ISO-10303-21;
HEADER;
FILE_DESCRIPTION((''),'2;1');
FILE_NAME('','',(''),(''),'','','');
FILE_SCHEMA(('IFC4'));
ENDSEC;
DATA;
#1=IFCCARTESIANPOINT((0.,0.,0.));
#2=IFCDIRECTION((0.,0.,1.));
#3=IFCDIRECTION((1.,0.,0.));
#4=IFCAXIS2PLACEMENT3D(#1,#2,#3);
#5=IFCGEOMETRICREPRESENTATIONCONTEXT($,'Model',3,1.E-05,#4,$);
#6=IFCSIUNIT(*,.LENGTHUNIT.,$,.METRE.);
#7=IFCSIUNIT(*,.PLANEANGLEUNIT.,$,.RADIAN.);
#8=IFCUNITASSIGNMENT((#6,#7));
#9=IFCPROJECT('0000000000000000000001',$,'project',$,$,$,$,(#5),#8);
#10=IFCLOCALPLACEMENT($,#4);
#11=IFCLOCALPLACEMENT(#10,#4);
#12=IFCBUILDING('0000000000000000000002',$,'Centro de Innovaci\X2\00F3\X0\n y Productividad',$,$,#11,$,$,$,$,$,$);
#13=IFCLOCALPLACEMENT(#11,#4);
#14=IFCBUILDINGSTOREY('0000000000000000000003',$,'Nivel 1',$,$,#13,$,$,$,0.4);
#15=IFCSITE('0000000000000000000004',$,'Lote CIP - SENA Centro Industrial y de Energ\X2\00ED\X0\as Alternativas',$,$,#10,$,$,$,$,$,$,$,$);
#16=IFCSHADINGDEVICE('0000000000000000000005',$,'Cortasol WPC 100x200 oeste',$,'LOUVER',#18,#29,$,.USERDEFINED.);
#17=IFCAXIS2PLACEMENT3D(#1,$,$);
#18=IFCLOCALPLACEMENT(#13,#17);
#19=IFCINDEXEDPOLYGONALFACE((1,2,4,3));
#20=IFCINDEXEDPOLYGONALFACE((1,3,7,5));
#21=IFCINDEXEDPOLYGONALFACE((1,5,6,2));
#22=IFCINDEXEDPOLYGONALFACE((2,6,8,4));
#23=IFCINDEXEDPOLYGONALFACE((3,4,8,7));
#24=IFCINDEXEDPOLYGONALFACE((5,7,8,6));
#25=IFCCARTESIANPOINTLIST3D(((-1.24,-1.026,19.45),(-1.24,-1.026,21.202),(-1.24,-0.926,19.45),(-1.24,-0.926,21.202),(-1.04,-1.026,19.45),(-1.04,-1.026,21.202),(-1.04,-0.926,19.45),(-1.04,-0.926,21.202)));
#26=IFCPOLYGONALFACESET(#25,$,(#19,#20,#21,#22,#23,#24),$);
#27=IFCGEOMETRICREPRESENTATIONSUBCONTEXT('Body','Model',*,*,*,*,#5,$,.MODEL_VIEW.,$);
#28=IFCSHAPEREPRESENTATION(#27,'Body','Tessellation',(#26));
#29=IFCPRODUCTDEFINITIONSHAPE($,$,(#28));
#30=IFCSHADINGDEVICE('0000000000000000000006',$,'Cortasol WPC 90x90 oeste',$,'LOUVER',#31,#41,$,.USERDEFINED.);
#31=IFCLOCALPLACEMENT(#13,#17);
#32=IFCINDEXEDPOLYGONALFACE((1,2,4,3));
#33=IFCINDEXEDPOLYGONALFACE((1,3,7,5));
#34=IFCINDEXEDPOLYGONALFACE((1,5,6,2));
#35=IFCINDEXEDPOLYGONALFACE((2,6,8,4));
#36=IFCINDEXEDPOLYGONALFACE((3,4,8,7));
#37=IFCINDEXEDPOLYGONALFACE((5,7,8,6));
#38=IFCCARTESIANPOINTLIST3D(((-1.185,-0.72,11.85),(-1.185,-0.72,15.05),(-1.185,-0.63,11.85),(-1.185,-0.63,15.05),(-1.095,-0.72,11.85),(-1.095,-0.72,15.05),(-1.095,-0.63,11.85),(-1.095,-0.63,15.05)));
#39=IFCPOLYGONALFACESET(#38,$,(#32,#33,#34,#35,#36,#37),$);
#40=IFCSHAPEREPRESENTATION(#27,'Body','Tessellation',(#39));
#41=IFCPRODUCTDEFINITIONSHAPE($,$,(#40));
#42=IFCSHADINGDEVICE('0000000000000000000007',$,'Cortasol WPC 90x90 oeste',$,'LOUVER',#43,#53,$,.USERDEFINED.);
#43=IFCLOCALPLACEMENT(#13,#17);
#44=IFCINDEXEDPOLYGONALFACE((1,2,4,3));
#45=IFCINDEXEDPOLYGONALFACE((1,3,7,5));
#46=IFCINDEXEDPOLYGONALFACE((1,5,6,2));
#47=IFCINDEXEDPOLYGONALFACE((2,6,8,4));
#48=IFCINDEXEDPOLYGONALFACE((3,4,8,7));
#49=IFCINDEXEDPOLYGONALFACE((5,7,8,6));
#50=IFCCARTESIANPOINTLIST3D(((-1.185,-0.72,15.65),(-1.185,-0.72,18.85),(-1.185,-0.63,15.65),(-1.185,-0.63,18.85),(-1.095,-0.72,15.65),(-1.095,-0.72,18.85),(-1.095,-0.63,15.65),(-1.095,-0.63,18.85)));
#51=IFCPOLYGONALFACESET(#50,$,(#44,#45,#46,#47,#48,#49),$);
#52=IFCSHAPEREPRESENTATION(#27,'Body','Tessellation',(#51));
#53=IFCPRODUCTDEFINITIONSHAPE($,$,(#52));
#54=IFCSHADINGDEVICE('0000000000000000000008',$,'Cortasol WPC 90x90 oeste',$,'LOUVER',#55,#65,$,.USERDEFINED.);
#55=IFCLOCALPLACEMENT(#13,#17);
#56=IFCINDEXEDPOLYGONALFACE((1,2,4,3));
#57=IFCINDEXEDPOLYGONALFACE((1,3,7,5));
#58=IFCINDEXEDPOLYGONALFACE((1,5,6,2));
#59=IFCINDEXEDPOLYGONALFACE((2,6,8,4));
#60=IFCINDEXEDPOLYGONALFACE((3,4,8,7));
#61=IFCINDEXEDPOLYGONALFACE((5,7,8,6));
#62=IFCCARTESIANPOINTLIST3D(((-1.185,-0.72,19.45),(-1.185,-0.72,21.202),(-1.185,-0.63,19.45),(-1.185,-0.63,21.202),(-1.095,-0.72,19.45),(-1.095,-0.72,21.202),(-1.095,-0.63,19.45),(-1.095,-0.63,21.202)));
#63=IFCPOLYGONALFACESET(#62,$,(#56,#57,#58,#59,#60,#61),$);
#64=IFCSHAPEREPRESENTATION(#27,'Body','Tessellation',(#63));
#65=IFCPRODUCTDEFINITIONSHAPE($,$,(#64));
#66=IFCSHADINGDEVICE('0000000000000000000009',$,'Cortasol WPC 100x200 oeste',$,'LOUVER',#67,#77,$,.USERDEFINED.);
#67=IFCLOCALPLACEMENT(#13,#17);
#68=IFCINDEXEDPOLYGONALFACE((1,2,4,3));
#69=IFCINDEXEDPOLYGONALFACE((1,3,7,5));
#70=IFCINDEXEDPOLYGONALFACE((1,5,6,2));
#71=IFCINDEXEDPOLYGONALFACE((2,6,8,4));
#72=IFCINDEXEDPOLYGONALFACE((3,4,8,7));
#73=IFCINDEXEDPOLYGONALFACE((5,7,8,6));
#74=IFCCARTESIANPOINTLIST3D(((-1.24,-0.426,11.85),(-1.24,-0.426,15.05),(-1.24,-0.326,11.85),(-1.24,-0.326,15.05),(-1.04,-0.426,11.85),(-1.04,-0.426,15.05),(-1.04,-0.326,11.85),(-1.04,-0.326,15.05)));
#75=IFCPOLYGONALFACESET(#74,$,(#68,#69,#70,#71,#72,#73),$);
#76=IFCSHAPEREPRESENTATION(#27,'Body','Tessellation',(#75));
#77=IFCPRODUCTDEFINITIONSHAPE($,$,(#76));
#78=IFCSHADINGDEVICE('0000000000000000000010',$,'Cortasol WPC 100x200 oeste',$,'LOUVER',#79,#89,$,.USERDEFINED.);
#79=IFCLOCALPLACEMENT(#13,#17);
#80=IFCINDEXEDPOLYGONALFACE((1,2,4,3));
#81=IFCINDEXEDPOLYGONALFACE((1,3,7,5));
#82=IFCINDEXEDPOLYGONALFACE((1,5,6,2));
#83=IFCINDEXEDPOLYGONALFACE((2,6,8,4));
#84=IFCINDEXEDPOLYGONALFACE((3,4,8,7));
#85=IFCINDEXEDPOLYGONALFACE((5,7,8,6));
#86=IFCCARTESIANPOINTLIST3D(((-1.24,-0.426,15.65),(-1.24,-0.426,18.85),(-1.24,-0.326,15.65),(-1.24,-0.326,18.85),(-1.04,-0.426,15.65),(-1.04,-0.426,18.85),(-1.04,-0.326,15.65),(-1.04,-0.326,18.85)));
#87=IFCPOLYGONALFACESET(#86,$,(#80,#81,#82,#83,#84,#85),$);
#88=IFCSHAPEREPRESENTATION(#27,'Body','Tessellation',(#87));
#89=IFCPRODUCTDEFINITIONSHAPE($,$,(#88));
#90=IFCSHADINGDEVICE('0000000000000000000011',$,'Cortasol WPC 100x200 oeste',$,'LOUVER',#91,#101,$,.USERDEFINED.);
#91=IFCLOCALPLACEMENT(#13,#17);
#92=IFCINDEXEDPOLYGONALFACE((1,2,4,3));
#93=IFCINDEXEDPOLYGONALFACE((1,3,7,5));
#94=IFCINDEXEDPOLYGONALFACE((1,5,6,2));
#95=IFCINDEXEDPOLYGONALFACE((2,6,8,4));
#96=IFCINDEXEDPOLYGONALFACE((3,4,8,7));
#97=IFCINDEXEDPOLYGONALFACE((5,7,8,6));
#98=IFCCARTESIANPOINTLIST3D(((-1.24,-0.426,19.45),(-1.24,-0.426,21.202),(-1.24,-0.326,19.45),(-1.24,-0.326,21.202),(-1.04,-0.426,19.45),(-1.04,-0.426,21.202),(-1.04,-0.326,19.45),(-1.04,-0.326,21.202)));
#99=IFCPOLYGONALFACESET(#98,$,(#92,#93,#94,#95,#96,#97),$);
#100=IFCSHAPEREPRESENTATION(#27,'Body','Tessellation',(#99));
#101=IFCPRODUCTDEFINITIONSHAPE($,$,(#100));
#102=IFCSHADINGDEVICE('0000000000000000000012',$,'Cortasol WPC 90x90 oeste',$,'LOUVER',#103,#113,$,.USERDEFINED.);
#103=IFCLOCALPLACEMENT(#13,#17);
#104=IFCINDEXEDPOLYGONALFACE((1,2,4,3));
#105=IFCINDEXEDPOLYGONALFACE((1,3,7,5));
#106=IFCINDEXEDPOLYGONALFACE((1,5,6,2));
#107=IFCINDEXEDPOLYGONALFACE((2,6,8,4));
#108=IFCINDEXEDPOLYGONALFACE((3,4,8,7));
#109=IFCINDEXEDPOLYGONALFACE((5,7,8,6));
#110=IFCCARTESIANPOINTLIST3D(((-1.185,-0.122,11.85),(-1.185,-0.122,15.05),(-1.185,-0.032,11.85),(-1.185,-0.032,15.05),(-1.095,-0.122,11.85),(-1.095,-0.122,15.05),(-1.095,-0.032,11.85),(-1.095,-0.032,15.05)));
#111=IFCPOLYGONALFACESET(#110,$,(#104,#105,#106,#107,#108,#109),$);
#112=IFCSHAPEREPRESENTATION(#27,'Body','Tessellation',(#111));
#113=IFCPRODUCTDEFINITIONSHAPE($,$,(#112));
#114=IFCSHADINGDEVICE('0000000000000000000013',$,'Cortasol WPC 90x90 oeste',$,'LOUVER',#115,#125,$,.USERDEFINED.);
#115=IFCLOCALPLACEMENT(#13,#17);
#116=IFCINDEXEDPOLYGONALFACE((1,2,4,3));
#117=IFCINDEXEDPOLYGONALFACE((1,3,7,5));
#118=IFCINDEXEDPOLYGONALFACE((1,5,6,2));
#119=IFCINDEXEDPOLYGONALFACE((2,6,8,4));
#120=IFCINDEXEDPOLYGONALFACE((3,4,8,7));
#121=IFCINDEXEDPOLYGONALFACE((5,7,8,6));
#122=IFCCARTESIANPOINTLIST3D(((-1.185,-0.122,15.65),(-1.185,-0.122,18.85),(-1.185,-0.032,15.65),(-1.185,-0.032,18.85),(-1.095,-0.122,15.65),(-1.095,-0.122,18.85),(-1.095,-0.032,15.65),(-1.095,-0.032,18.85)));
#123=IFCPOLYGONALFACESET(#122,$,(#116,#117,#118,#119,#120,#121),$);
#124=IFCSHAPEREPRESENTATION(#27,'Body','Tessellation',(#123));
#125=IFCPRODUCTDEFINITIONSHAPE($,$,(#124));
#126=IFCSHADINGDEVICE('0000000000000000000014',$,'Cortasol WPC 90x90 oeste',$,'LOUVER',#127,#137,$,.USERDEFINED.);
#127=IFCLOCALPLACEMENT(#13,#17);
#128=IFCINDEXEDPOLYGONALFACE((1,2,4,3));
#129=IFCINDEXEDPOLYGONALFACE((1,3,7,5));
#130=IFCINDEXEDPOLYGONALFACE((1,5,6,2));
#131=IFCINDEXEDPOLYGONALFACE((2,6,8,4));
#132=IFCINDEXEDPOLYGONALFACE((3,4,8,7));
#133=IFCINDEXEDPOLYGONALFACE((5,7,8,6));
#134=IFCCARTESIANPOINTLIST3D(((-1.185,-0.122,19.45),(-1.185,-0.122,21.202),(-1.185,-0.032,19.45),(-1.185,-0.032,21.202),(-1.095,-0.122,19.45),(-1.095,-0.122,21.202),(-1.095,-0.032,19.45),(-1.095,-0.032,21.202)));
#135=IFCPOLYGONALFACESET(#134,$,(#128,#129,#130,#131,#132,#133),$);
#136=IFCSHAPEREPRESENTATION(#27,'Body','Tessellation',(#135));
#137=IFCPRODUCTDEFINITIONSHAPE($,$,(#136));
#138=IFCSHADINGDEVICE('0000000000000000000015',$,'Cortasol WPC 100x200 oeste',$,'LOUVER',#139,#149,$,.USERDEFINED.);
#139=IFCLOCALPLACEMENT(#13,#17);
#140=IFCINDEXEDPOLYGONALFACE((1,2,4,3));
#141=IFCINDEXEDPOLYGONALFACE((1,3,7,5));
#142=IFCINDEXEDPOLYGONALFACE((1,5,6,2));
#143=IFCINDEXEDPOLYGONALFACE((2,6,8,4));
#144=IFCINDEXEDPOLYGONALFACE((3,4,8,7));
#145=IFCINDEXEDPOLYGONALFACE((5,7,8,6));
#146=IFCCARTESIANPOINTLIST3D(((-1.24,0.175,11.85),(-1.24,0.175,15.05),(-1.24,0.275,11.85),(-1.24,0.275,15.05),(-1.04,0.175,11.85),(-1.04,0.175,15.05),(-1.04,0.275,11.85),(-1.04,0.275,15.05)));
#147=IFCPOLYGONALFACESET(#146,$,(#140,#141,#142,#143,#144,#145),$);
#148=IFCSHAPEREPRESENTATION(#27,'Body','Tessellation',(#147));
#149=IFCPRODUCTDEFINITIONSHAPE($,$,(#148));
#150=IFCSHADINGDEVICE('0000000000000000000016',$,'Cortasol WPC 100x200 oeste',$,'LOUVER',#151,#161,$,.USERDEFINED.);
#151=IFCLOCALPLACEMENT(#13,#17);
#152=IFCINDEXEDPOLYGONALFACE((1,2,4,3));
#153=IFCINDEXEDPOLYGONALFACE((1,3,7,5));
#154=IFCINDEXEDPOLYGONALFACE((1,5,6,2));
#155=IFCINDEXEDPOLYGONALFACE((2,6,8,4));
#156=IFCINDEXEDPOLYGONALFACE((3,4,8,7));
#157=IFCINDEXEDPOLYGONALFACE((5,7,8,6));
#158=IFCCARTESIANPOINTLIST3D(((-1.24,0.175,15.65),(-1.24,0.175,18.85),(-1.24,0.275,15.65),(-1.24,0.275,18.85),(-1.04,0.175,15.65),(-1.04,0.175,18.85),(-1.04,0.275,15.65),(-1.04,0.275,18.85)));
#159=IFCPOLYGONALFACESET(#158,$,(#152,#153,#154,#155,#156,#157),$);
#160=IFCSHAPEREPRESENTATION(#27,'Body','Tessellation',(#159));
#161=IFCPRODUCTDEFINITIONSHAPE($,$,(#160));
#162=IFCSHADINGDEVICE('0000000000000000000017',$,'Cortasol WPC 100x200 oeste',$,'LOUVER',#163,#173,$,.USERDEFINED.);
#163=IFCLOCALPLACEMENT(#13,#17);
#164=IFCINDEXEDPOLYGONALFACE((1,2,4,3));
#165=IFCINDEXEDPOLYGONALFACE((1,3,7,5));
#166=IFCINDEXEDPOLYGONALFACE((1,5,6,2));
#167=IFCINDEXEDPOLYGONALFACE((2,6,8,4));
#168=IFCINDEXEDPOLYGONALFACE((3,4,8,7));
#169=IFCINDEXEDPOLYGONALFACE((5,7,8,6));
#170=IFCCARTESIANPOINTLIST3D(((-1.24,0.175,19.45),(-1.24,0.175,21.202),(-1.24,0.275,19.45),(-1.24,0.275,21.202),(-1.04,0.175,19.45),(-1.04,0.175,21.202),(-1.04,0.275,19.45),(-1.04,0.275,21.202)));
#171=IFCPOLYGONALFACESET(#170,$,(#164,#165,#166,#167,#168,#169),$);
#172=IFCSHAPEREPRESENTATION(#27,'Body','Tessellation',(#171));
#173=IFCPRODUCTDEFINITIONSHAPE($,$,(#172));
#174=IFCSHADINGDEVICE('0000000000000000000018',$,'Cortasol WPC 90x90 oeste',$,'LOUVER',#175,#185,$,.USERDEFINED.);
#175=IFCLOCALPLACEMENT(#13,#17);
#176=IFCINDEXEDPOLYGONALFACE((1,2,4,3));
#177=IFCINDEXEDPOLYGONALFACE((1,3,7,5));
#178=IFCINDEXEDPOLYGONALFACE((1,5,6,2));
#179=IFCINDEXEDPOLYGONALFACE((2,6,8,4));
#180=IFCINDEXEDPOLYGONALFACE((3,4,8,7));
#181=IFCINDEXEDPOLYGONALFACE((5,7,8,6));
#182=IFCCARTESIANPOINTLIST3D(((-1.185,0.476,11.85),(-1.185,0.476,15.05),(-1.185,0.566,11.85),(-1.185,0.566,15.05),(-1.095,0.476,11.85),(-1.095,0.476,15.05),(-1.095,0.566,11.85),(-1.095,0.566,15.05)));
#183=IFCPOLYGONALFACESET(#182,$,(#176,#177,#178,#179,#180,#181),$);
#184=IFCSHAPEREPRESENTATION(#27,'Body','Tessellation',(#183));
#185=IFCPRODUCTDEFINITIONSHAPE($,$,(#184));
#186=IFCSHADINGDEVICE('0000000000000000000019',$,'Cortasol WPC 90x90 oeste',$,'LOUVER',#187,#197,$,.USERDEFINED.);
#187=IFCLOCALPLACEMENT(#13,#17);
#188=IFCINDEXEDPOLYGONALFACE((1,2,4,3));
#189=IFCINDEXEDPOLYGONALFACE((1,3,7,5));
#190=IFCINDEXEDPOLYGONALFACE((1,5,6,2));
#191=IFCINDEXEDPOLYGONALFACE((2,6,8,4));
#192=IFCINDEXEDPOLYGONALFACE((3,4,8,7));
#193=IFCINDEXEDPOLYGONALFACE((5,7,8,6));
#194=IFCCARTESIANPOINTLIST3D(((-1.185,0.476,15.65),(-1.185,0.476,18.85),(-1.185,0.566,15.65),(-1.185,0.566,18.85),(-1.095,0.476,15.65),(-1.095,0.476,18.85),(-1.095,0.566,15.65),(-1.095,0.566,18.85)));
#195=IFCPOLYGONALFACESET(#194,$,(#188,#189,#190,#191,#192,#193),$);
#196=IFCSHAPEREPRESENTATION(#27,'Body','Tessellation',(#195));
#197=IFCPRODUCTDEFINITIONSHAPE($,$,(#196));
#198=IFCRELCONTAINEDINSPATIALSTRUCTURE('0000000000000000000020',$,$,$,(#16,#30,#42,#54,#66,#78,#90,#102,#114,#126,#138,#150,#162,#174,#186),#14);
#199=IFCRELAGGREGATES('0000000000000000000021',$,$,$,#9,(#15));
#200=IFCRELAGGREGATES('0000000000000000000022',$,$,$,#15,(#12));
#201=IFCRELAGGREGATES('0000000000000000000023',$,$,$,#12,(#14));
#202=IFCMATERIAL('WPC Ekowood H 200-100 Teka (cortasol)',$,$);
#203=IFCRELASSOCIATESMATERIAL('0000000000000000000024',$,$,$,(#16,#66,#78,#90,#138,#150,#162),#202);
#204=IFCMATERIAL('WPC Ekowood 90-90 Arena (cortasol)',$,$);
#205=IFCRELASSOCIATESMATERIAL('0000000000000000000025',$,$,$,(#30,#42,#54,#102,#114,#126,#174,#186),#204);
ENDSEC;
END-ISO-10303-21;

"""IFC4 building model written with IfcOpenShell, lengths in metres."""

from ifc_helpers import new_model, si_unit, frame, origin_with_axes, place, context, subcontext, project, spatial, polyline, outline, extrude, material, element, save


model = new_model("IFC4")

# Units and contexts
model_context = context("Model", 3, precision=1e-05, world=origin_with_axes())
body_context = subcontext(model_context, "Body", "Model", "MODEL_VIEW")
ifc_project = project(units=[si_unit("LENGTHUNIT", "METRE"), si_unit("PLANEANGLEUNIT", "RADIAN")], contexts=[model_context])

# Site, building, storey
site_placement = place(None, origin_with_axes())
site = spatial("IfcSite", under=ifc_project, at=site_placement, Name="Lote CIP - SENA Centro Industrial y de Energías Alternativas")
building_placement = place(site_placement, origin_with_axes())
building = spatial("IfcBuilding", under=site, at=building_placement, Name="Centro de Innovación y Productividad")
storey_placement = place(building_placement, origin_with_axes())
storey = spatial("IfcBuildingStorey", under=building, at=storey_placement, Name="Nivel 1", Elevation=0.4)

# Shading devices
ifc_material_1 = material(Name="WPC Ekowood H 200-100 Teka (cortasol)")
shading_device_1_placement = place(storey_placement, origin_with_axes())
element("IfcShadingDevice", 1, at=shading_device_1_placement, inside=storey, material=ifc_material_1, Name="Cortasol WPC 100x200 oeste", ObjectType="LOUVER", PredefinedType="USERDEFINED", context=body_context, shape_type="SweptSolid", body=[
    extrude(outline(polyline([(-1.04, -1.026), (-1.24, -1.026), (-1.24, -0.926), (-1.04, -0.926), (-1.04, -1.026)])), frame((0.0, 0.0, 19.45)), (0.0, 0.0, 1.0), 1.752),
])
ifc_material_2 = material(Name="WPC Ekowood 90-90 Arena (cortasol)")
shading_device_2_placement = place(storey_placement, origin_with_axes())
element("IfcShadingDevice", 2, at=shading_device_2_placement, inside=storey, material=ifc_material_2, Name="Cortasol WPC 90x90 oeste", ObjectType="LOUVER", PredefinedType="USERDEFINED", context=body_context, shape_type="SweptSolid", body=[
    extrude(outline(polyline([(-1.095, -0.72), (-1.185, -0.72), (-1.185, -0.63), (-1.095, -0.63), (-1.095, -0.72)])), frame((0.0, 0.0, 11.85)), (0.0, 0.0, 1.0), 3.2),
])
shading_device_3_placement = place(storey_placement, origin_with_axes())
element("IfcShadingDevice", 3, at=shading_device_3_placement, inside=storey, material=ifc_material_2, Name="Cortasol WPC 90x90 oeste", ObjectType="LOUVER", PredefinedType="USERDEFINED", context=body_context, shape_type="SweptSolid", body=[
    extrude(outline(polyline([(-1.095, -0.72), (-1.185, -0.72), (-1.185, -0.63), (-1.095, -0.63), (-1.095, -0.72)])), frame((0.0, 0.0, 15.65)), (0.0, 0.0, 1.0), 3.2),
])
shading_device_4_placement = place(storey_placement, origin_with_axes())
element("IfcShadingDevice", 4, at=shading_device_4_placement, inside=storey, material=ifc_material_2, Name="Cortasol WPC 90x90 oeste", ObjectType="LOUVER", PredefinedType="USERDEFINED", context=body_context, shape_type="SweptSolid", body=[
    extrude(outline(polyline([(-1.095, -0.72), (-1.185, -0.72), (-1.185, -0.63), (-1.095, -0.63), (-1.095, -0.72)])), frame((0.0, 0.0, 19.45)), (0.0, 0.0, 1.0), 1.752),
])
shading_device_5_placement = place(storey_placement, origin_with_axes())
element("IfcShadingDevice", 5, at=shading_device_5_placement, inside=storey, material=ifc_material_1, Name="Cortasol WPC 100x200 oeste", ObjectType="LOUVER", PredefinedType="USERDEFINED", context=body_context, shape_type="SweptSolid", body=[
    extrude(outline(polyline([(-1.04, -0.426), (-1.24, -0.426), (-1.24, -0.326), (-1.04, -0.326), (-1.04, -0.426)])), frame((0.0, 0.0, 11.85)), (0.0, 0.0, 1.0), 3.2),
])
shading_device_6_placement = place(storey_placement, origin_with_axes())
element("IfcShadingDevice", 6, at=shading_device_6_placement, inside=storey, material=ifc_material_1, Name="Cortasol WPC 100x200 oeste", ObjectType="LOUVER", PredefinedType="USERDEFINED", context=body_context, shape_type="SweptSolid", body=[
    extrude(outline(polyline([(-1.04, -0.426), (-1.24, -0.426), (-1.24, -0.326), (-1.04, -0.326), (-1.04, -0.426)])), frame((0.0, 0.0, 15.65)), (0.0, 0.0, 1.0), 3.2),
])
shading_device_7_placement = place(storey_placement, origin_with_axes())
element("IfcShadingDevice", 7, at=shading_device_7_placement, inside=storey, material=ifc_material_1, Name="Cortasol WPC 100x200 oeste", ObjectType="LOUVER", PredefinedType="USERDEFINED", context=body_context, shape_type="SweptSolid", body=[
    extrude(outline(polyline([(-1.04, -0.426), (-1.24, -0.426), (-1.24, -0.326), (-1.04, -0.326), (-1.04, -0.426)])), frame((0.0, 0.0, 19.45)), (0.0, 0.0, 1.0), 1.752),
])
shading_device_8_placement = place(storey_placement, origin_with_axes())
element("IfcShadingDevice", 8, at=shading_device_8_placement, inside=storey, material=ifc_material_2, Name="Cortasol WPC 90x90 oeste", ObjectType="LOUVER", PredefinedType="USERDEFINED", context=body_context, shape_type="SweptSolid", body=[
    extrude(outline(polyline([(-1.095, -0.122), (-1.185, -0.122), (-1.185, -0.032), (-1.095, -0.032), (-1.095, -0.122)])), frame((0.0, 0.0, 11.85)), (0.0, 0.0, 1.0), 3.2),
])
shading_device_9_placement = place(storey_placement, origin_with_axes())
element("IfcShadingDevice", 9, at=shading_device_9_placement, inside=storey, material=ifc_material_2, Name="Cortasol WPC 90x90 oeste", ObjectType="LOUVER", PredefinedType="USERDEFINED", context=body_context, shape_type="SweptSolid", body=[
    extrude(outline(polyline([(-1.095, -0.122), (-1.185, -0.122), (-1.185, -0.032), (-1.095, -0.032), (-1.095, -0.122)])), frame((0.0, 0.0, 15.65)), (0.0, 0.0, 1.0), 3.2),
])
shading_device_10_placement = place(storey_placement, origin_with_axes())
element("IfcShadingDevice", 10, at=shading_device_10_placement, inside=storey, material=ifc_material_2, Name="Cortasol WPC 90x90 oeste", ObjectType="LOUVER", PredefinedType="USERDEFINED", context=body_context, shape_type="SweptSolid", body=[
    extrude(outline(polyline([(-1.095, -0.122), (-1.185, -0.122), (-1.185, -0.032), (-1.095, -0.032), (-1.095, -0.122)])), frame((0.0, 0.0, 19.45)), (0.0, 0.0, 1.0), 1.752),
])
shading_device_11_placement = place(storey_placement, origin_with_axes())
element("IfcShadingDevice", 11, at=shading_device_11_placement, inside=storey, material=ifc_material_1, Name="Cortasol WPC 100x200 oeste", ObjectType="LOUVER", PredefinedType="USERDEFINED", context=body_context, shape_type="SweptSolid", body=[
    extrude(outline(polyline([(-1.04, 0.175), (-1.24, 0.175), (-1.24, 0.275), (-1.04, 0.275), (-1.04, 0.175)])), frame((0.0, 0.0, 11.85)), (0.0, 0.0, 1.0), 3.2),
])
shading_device_12_placement = place(storey_placement, origin_with_axes())
element("IfcShadingDevice", 12, at=shading_device_12_placement, inside=storey, material=ifc_material_1, Name="Cortasol WPC 100x200 oeste", ObjectType="LOUVER", PredefinedType="USERDEFINED", context=body_context, shape_type="SweptSolid", body=[
    extrude(outline(polyline([(-1.04, 0.175), (-1.24, 0.175), (-1.24, 0.275), (-1.04, 0.275), (-1.04, 0.175)])), frame((0.0, 0.0, 15.65)), (0.0, 0.0, 1.0), 3.2),
])
shading_device_13_placement = place(storey_placement, origin_with_axes())
element("IfcShadingDevice", 13, at=shading_device_13_placement, inside=storey, material=ifc_material_1, Name="Cortasol WPC 100x200 oeste", ObjectType="LOUVER", PredefinedType="USERDEFINED", context=body_context, shape_type="SweptSolid", body=[
    extrude(outline(polyline([(-1.04, 0.175), (-1.24, 0.175), (-1.24, 0.275), (-1.04, 0.275), (-1.04, 0.175)])), frame((0.0, 0.0, 19.45)), (0.0, 0.0, 1.0), 1.752),
])
shading_device_14_placement = place(storey_placement, origin_with_axes())
element("IfcShadingDevice", 14, at=shading_device_14_placement, inside=storey, material=ifc_material_2, Name="Cortasol WPC 90x90 oeste", ObjectType="LOUVER", PredefinedType="USERDEFINED", context=body_context, shape_type="SweptSolid", body=[
    extrude(outline(polyline([(-1.095, 0.476), (-1.185, 0.476), (-1.185, 0.566), (-1.095, 0.566), (-1.095, 0.476)])), frame((0.0, 0.0, 11.85)), (0.0, 0.0, 1.0), 3.2),
])
shading_device_15_placement = place(storey_placement, origin_with_axes())
element("IfcShadingDevice", 15, at=shading_device_15_placement, inside=storey, material=ifc_material_2, Name="Cortasol WPC 90x90 oeste", ObjectType="LOUVER", PredefinedType="USERDEFINED", context=body_context, shape_type="SweptSolid", body=[
    extrude(outline(polyline([(-1.095, 0.476), (-1.185, 0.476), (-1.185, 0.566), (-1.095, 0.566), (-1.095, 0.476)])), frame((0.0, 0.0, 15.65)), (0.0, 0.0, 1.0), 3.2),
])

save(model, "model.ifc")
